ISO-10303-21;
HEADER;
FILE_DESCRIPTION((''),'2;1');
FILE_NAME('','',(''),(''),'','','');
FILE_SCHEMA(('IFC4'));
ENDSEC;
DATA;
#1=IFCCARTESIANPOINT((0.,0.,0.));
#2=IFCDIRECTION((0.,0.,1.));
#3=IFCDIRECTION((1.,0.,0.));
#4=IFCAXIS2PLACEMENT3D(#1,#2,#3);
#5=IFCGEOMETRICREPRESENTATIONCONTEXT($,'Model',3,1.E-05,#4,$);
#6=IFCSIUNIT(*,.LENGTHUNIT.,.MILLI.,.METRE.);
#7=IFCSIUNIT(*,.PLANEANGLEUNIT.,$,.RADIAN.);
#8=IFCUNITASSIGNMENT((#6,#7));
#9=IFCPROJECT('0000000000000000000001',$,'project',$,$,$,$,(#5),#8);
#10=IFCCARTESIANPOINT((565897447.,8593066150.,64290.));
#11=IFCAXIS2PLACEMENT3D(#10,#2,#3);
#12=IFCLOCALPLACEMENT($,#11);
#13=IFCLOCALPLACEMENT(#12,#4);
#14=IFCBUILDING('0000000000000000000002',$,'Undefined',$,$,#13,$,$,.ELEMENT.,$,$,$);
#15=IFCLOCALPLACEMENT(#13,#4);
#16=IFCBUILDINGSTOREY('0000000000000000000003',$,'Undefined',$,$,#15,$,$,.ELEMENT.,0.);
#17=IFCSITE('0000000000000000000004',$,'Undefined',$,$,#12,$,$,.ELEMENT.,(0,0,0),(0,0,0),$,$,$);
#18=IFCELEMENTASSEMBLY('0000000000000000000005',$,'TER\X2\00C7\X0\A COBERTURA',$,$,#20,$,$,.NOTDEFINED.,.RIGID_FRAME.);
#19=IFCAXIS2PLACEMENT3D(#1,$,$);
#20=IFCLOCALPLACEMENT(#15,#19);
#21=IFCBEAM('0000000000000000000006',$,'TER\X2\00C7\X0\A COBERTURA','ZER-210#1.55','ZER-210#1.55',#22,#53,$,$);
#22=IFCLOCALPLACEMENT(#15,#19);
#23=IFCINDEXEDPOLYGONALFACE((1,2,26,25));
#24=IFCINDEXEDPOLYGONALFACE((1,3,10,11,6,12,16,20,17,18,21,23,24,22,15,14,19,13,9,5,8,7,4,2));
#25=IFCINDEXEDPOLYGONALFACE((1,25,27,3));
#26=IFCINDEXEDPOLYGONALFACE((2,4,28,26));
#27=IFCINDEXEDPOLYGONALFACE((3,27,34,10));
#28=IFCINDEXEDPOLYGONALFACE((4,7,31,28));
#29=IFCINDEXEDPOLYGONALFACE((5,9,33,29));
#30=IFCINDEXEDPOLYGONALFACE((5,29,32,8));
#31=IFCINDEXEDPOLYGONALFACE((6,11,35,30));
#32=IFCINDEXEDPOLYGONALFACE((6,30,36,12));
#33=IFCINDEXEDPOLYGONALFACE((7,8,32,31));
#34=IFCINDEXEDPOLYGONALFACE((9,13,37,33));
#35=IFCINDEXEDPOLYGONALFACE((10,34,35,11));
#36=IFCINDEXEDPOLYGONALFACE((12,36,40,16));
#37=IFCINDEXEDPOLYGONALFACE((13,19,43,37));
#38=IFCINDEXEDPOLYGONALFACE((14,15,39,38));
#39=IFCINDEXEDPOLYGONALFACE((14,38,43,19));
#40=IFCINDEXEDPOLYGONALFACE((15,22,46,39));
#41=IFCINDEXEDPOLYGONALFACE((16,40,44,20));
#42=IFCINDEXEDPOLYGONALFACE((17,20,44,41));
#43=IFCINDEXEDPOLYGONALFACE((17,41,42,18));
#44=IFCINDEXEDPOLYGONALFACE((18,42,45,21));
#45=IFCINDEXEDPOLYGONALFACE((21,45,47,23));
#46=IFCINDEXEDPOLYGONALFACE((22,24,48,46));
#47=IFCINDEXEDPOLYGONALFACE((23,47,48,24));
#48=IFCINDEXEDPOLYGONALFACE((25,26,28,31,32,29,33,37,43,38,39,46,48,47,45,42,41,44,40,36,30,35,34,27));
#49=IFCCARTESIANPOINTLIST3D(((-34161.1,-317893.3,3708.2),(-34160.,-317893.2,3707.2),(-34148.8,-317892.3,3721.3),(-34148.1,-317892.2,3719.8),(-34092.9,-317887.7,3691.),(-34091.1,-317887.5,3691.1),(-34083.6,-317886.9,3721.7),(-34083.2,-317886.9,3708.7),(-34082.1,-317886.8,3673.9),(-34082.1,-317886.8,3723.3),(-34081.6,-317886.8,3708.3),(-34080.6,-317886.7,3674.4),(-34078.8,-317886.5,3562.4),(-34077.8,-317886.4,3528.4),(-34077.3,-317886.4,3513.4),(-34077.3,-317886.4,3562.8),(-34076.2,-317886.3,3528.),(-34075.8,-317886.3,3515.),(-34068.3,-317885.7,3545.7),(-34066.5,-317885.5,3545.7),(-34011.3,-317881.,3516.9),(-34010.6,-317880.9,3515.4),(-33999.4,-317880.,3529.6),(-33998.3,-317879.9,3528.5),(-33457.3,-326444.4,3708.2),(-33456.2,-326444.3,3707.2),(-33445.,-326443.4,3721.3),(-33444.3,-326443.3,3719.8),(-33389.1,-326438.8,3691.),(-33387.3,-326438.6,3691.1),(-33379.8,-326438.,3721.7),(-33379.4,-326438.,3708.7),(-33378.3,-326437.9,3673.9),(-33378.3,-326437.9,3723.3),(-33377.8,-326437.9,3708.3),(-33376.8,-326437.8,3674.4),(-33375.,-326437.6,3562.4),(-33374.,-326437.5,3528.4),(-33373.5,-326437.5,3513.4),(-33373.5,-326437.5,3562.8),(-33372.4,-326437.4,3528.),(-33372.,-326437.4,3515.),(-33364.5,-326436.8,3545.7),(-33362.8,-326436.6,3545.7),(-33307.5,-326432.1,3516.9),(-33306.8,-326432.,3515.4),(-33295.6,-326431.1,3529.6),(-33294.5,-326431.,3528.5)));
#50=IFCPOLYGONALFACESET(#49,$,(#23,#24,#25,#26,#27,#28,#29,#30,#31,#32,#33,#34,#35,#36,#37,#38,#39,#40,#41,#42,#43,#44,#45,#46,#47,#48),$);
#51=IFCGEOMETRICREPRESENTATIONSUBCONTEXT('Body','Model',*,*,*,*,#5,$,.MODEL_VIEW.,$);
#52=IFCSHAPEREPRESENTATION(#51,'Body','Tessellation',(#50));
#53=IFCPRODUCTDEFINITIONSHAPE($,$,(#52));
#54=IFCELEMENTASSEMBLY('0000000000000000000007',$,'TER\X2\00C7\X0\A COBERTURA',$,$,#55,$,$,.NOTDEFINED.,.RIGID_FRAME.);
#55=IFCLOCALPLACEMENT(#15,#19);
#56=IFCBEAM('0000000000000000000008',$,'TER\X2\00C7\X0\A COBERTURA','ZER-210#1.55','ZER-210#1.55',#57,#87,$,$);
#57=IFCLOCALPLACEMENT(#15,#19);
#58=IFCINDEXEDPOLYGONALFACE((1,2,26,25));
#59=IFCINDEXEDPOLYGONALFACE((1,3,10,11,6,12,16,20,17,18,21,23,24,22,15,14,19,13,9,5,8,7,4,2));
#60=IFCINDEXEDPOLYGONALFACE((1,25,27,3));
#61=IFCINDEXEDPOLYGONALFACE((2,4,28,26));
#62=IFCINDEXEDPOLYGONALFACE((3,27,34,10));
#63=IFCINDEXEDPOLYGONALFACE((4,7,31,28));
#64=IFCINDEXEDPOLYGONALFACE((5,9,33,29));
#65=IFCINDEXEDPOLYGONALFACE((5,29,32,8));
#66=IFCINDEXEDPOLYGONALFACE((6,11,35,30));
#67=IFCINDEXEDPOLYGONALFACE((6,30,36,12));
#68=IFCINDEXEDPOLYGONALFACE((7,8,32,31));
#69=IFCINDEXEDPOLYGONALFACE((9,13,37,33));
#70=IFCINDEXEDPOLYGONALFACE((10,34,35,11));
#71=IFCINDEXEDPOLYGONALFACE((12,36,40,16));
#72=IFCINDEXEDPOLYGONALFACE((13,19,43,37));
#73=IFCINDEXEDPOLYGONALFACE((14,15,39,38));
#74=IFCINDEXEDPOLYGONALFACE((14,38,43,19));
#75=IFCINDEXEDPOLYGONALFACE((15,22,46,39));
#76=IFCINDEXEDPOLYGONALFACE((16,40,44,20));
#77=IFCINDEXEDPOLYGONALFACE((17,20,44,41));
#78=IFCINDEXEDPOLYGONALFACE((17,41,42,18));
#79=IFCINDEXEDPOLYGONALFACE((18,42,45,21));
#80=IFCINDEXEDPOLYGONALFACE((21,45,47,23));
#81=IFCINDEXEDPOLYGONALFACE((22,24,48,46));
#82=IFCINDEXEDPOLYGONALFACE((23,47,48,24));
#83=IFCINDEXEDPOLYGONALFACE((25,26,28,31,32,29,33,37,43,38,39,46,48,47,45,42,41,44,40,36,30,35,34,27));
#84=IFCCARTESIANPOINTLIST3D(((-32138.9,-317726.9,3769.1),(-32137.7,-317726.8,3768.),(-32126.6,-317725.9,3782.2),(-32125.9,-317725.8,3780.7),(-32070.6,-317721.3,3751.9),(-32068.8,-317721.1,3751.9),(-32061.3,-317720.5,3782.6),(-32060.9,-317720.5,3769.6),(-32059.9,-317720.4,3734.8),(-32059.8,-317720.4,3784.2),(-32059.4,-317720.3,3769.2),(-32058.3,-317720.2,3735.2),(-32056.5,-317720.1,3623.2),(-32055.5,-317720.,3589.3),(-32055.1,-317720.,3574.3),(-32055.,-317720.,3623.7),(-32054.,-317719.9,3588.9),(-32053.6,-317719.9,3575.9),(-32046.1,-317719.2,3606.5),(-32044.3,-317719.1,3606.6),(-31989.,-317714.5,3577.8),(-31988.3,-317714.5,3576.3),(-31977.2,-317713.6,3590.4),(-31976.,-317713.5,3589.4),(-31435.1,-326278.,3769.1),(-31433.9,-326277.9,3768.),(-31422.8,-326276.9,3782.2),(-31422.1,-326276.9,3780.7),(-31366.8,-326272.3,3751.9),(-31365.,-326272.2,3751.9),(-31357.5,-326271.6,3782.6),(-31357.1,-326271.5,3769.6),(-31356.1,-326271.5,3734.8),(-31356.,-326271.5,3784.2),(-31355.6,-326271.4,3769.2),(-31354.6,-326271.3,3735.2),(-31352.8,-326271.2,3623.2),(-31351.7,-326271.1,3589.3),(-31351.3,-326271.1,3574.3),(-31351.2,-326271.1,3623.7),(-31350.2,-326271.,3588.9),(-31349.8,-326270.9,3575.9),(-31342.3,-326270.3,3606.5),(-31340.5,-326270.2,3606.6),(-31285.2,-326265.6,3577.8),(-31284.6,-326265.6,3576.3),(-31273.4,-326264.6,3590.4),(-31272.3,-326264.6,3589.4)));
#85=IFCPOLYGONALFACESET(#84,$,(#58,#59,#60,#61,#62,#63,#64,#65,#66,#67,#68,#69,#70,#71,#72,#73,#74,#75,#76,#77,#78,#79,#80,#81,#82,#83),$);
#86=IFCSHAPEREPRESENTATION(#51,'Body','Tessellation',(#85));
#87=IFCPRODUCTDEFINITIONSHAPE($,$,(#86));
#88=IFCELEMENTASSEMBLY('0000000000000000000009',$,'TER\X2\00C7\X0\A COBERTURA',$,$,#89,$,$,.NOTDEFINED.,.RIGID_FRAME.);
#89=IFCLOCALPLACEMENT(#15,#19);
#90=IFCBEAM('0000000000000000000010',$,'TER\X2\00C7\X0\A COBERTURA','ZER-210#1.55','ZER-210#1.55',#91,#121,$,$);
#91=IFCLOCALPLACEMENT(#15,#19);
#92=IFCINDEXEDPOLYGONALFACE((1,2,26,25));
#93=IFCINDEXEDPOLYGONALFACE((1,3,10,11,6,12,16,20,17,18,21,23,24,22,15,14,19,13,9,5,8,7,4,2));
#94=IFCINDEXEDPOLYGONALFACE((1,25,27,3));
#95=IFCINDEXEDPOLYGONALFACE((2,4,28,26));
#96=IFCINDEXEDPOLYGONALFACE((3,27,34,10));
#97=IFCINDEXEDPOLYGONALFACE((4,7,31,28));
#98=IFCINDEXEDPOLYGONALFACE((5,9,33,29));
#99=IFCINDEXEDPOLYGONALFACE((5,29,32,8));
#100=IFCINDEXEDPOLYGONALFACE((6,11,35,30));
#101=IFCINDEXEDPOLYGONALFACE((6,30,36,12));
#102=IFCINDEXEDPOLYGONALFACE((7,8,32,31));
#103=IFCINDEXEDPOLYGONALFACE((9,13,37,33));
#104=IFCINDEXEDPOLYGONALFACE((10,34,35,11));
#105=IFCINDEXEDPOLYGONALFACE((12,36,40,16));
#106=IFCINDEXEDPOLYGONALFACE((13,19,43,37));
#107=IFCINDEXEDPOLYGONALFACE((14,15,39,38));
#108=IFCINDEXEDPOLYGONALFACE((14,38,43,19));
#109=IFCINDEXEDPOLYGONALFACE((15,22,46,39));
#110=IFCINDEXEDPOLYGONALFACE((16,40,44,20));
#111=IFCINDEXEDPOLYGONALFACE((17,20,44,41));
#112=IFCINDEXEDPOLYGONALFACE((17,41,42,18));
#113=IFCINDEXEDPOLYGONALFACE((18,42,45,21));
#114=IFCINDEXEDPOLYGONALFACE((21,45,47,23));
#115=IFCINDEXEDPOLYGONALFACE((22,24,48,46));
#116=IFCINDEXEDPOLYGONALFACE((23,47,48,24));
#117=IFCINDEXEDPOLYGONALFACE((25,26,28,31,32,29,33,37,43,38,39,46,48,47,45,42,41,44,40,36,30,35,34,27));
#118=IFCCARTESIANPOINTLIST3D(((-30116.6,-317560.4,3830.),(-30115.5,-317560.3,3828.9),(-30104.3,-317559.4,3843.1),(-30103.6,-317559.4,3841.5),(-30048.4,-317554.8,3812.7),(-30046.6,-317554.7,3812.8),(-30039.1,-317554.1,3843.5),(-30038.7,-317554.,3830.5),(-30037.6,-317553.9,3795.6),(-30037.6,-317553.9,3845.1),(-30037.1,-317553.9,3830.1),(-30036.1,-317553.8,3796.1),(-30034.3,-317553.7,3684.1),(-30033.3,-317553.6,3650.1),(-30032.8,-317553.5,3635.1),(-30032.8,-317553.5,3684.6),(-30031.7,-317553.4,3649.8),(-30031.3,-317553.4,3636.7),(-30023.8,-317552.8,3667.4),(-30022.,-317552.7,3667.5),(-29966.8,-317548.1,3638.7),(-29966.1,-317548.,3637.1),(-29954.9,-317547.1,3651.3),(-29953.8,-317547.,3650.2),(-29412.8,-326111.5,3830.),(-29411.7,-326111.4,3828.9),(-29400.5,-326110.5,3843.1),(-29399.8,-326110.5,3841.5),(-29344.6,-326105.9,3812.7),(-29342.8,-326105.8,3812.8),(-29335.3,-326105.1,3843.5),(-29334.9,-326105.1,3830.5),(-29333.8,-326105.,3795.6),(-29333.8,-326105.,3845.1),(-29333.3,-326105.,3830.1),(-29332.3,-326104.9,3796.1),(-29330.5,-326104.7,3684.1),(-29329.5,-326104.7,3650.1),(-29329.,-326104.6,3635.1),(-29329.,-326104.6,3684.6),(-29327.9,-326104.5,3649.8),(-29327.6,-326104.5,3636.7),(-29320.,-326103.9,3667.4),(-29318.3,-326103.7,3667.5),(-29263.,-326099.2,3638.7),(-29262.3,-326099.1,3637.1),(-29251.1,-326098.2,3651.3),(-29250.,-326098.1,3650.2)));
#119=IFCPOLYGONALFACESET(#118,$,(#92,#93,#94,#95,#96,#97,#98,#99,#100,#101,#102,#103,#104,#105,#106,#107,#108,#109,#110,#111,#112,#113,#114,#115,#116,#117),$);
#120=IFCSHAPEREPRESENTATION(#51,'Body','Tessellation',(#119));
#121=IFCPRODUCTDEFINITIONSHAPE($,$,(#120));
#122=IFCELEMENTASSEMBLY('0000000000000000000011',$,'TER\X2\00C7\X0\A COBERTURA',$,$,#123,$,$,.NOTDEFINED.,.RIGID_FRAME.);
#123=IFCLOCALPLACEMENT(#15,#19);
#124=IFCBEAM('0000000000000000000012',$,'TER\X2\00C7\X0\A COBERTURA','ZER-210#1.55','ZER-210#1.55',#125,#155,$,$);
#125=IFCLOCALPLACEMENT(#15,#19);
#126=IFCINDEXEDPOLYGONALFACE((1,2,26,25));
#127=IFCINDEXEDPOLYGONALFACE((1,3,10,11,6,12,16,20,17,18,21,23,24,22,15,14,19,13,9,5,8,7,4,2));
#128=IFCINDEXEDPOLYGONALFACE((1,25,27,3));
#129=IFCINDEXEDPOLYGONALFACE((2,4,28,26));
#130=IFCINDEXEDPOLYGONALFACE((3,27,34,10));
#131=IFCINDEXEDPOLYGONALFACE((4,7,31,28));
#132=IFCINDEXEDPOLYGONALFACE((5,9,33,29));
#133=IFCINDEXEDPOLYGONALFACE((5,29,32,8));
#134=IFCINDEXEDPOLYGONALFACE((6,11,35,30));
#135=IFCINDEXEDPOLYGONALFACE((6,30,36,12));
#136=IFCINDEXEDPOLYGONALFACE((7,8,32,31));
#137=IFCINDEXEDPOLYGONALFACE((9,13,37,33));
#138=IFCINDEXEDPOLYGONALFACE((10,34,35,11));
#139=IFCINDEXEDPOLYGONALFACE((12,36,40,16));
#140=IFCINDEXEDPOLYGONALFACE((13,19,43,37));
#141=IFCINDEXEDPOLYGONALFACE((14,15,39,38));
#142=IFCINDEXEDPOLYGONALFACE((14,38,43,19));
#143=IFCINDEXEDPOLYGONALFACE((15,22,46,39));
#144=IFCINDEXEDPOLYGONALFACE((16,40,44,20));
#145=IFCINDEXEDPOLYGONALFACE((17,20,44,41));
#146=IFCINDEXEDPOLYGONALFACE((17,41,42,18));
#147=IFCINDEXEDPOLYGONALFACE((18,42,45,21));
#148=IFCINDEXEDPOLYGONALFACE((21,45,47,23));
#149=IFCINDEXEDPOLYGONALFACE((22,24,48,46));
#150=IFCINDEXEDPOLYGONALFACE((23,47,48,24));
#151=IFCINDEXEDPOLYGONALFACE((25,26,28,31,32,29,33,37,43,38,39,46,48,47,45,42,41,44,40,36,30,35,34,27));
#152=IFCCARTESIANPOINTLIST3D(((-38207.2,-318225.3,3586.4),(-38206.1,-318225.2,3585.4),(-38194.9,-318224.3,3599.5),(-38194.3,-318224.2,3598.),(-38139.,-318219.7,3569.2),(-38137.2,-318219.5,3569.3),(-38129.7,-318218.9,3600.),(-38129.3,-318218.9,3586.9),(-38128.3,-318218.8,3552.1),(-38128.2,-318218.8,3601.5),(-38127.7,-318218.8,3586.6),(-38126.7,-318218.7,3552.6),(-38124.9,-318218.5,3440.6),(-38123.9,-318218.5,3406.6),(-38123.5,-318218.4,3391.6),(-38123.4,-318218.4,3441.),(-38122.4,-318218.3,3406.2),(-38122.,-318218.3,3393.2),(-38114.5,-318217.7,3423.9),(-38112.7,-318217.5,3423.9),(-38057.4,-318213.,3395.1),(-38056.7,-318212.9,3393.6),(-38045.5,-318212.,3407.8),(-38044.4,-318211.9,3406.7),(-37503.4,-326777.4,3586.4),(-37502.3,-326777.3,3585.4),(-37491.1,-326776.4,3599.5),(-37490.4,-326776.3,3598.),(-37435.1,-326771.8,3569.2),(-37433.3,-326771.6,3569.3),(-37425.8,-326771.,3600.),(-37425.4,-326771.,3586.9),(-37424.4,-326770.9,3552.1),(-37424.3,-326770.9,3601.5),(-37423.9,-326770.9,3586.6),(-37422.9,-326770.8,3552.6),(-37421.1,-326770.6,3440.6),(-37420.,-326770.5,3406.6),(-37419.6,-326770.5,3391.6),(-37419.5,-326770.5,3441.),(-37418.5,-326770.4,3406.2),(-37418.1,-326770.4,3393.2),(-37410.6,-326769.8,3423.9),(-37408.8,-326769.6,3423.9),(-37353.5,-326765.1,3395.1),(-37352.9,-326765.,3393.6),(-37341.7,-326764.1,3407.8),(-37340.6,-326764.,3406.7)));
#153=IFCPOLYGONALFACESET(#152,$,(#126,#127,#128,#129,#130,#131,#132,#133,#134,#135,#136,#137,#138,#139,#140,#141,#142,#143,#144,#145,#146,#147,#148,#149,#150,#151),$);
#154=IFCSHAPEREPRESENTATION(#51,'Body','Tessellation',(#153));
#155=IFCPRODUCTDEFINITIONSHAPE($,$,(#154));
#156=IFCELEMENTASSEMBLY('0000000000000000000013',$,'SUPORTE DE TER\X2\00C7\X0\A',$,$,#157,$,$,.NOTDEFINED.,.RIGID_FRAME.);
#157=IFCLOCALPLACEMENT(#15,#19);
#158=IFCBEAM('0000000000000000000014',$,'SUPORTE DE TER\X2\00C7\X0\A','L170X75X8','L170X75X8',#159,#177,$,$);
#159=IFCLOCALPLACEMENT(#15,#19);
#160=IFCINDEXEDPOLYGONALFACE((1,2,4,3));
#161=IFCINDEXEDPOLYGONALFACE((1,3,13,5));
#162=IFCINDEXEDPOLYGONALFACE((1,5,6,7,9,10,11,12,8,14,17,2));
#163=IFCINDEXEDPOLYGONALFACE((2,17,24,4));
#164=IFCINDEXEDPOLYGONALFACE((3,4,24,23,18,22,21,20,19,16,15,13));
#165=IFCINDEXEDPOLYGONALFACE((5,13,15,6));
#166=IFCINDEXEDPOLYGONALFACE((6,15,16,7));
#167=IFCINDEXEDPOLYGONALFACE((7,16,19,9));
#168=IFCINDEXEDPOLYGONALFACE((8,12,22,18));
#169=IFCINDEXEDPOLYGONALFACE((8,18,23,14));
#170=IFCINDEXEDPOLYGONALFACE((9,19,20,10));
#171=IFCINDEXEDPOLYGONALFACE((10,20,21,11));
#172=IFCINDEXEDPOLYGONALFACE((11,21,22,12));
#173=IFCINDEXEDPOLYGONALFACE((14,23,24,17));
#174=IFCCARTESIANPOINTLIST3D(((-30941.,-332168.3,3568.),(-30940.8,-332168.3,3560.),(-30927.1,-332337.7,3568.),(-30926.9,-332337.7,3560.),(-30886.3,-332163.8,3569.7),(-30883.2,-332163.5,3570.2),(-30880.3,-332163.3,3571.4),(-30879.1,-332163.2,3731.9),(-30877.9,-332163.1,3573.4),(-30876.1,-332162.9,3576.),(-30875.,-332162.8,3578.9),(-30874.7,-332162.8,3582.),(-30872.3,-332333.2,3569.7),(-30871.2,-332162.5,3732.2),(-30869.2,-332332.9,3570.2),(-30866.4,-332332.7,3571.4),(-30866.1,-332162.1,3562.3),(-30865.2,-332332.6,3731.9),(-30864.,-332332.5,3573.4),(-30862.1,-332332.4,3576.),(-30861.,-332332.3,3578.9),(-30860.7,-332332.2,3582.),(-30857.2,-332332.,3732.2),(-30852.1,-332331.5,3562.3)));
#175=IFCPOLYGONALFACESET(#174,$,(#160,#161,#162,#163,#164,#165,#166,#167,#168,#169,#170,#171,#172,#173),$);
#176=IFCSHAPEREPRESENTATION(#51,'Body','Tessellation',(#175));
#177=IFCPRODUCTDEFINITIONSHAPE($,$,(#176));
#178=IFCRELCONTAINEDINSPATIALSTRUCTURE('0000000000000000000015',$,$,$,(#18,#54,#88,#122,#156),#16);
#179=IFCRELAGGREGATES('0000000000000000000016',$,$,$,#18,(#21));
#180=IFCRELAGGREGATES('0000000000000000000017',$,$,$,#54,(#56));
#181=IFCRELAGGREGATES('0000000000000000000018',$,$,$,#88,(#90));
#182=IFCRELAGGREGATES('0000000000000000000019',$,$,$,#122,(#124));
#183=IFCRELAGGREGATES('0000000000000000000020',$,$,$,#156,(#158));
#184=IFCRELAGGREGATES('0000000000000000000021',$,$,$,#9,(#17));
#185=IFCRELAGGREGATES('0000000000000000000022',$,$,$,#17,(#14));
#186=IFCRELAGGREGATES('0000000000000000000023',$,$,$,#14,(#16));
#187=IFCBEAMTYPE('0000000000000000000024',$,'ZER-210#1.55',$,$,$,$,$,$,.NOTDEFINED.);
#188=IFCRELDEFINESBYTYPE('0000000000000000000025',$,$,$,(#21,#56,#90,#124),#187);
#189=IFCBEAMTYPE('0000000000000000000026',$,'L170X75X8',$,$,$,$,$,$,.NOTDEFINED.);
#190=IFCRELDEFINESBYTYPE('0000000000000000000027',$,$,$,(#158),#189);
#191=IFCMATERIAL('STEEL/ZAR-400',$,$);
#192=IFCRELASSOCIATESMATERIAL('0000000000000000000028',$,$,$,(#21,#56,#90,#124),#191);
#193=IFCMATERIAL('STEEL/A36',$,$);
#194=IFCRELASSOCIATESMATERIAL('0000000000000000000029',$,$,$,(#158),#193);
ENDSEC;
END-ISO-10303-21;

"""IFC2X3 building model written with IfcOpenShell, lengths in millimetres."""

from ifc_helpers import new_model, si_unit, frame, origin_with_axes, origin_2d_with_axis, place, context, subcontext, project, spatial, polyline, l_section, outline, extrude, material, type_object, element, aggregate, save


model = new_model("IFC2X3")

# Units and contexts
model_context = context("Model", 3, precision=1e-05, world=origin_with_axes())
body_context = subcontext(model_context, "Body", "Model", "MODEL_VIEW")
ifc_project = project(units=[si_unit("LENGTHUNIT", "METRE", prefix="MILLI"), si_unit("PLANEANGLEUNIT", "RADIAN")], contexts=[model_context])

# Site, building, storey
site_placement = place(None, frame((565897447.0, 8593066150.0, 64290.0), z_axis=(0.0, 0.0, 1.0), x_axis=(1.0, 0.0, 0.0)))
site = spatial("IfcSite", under=ifc_project, at=site_placement, Name="Undefined", CompositionType="ELEMENT", RefLatitude=(0, 0, 0), RefLongitude=(0, 0, 0))
building_placement = place(site_placement, origin_with_axes())
building = spatial("IfcBuilding", under=site, at=building_placement, Name="Undefined", CompositionType="ELEMENT")
storey_placement = place(building_placement, origin_with_axes())
storey = spatial("IfcBuildingStorey", under=building, at=storey_placement, Name="Undefined", CompositionType="ELEMENT", Elevation=0.0)

# Element assemblies, beams
ifc_material_1 = material(Name="STEEL/ZAR-400")
beam_type_1 = type_object("IfcBeamType", Name="ZER-210#1.55", PredefinedType="NOTDEFINED")
assembly_1_placement = place(storey_placement, origin_with_axes())
assembly_1 = element("IfcElementAssembly", 1, at=assembly_1_placement, inside=storey, Name="TERÇA COBERTURA", AssemblyPlace="NOTDEFINED", PredefinedType="RIGID_FRAME")
beam_1_placement = place(assembly_1_placement, frame((-33375.9, -326437.7, 3618.4), z_axis=(-0.029885, -0.00246, 0.99955), x_axis=(-0.082025, 0.99663, 0.0)))
beam_1 = element("IfcBeam", 2, at=beam_1_placement, type_object=beam_type_1, material=ifc_material_1, Name="TERÇA COBERTURA", Description="ZER-210#1.55", ObjectType="ZER-210#1.55", context=body_context, shape_type="SweptSolid", body=[
    extrude(outline(polyline([(65.6, -103.4), (77.9, -91.2), (79.0, -92.3), (66.2, -105.0), (-0.8, -105.0), (-0.8, -90.0), (9.2, -73.0), (-0.8, -56.0), (-0.8, 55.6), (-11.0, 73.0), (-0.8, 90.4), (-0.8, 103.5), (-65.6, 103.4), (-77.9, 91.2), (-79.0, 92.3), (-66.2, 105.0), (0.8, 105.0), (0.8, 90.0), (-9.2, 73.0), (0.8, 56.0), (0.8, -55.6), (11.0, -73.0), (0.8, -90.4), (0.8, -103.5), (65.6, -103.4)])), frame((8580.0, 0.0, 0.0), z_axis=(-1.0, 0.0, 0.0), x_axis=(0.0, -1.0, 0.0)), (0.0, 0.0, 1.0), 8580.0),
])
aggregate(assembly_1, [beam_1])
assembly_2_placement = place(storey_placement, origin_with_axes())
assembly_2 = element("IfcElementAssembly", 3, at=assembly_2_placement, inside=storey, Name="TERÇA COBERTURA", AssemblyPlace="NOTDEFINED", PredefinedType="RIGID_FRAME")
beam_2_placement = place(assembly_2_placement, frame((-31353.7, -326271.3, 3679.2), z_axis=(-0.029885, -0.00246, 0.99955), x_axis=(-0.082025, 0.99663, 0.0)))
beam_2 = element("IfcBeam", 4, at=beam_2_placement, type_object=beam_type_1, material=ifc_material_1, Name="TERÇA COBERTURA", Description="ZER-210#1.55", ObjectType="ZER-210#1.55", context=body_context, shape_type="SweptSolid", body=[
    extrude(outline(polyline([(65.6, -103.4), (77.9, -91.2), (79.0, -92.3), (66.2, -105.0), (-0.8, -105.0), (-0.8, -90.0), (9.2, -73.0), (-0.8, -56.0), (-0.8, 55.6), (-11.0, 73.0), (-0.8, 90.4), (-0.8, 103.5), (-65.6, 103.4), (-77.9, 91.2), (-79.0, 92.3), (-66.2, 105.0), (0.8, 105.0), (0.8, 90.0), (-9.2, 73.0), (0.8, 56.0), (0.8, -55.6), (11.0, -73.0), (0.8, -90.4), (0.8, -103.5), (65.6, -103.4)])), frame((8580.0, 0.0, 0.0), z_axis=(-1.0, 0.0, 0.0), x_axis=(0.0, -1.0, 0.0)), (0.0, 0.0, 1.0), 8580.0),
])
aggregate(assembly_2, [beam_2])
assembly_3_placement = place(storey_placement, origin_with_axes())
assembly_3 = element("IfcElementAssembly", 5, at=assembly_3_placement, inside=storey, Name="TERÇA COBERTURA", AssemblyPlace="NOTDEFINED", PredefinedType="RIGID_FRAME")
beam_3_placement = place(assembly_3_placement, frame((-29331.4, -326104.8, 3740.1), z_axis=(-0.029885, -0.00246, 0.99955), x_axis=(-0.082025, 0.99663, 0.0)))
beam_3 = element("IfcBeam", 6, at=beam_3_placement, type_object=beam_type_1, material=ifc_material_1, Name="TERÇA COBERTURA", Description="ZER-210#1.55", ObjectType="ZER-210#1.55", context=body_context, shape_type="SweptSolid", body=[
    extrude(outline(polyline([(65.6, -103.4), (77.9, -91.2), (79.0, -92.3), (66.2, -105.0), (-0.8, -105.0), (-0.8, -90.0), (9.2, -73.0), (-0.8, -56.0), (-0.8, 55.6), (-11.0, 73.0), (-0.8, 90.4), (-0.8, 103.5), (-65.6, 103.4), (-77.9, 91.2), (-79.0, 92.3), (-66.2, 105.0), (0.8, 105.0), (0.8, 90.0), (-9.2, 73.0), (0.8, 56.0), (0.8, -55.6), (11.0, -73.0), (0.8, -90.4), (0.8, -103.5), (65.6, -103.4)])), frame((8580.0, 0.0, 0.0), z_axis=(-1.0, 0.0, 0.0), x_axis=(0.0, -1.0, 0.0)), (0.0, 0.0, 1.0), 8580.0),
])
aggregate(assembly_3, [beam_3])
assembly_4_placement = place(storey_placement, origin_with_axes())
assembly_4 = element("IfcElementAssembly", 7, at=assembly_4_placement, inside=storey, Name="TERÇA COBERTURA", AssemblyPlace="NOTDEFINED", PredefinedType="RIGID_FRAME")
beam_4_placement = place(assembly_4_placement, frame((-37422.0, -326770.7, 3496.6), z_axis=(-0.029885, -0.00246, 0.99955), x_axis=(-0.082025, 0.99663, 0.0)))
beam_4 = element("IfcBeam", 8, at=beam_4_placement, type_object=beam_type_1, material=ifc_material_1, Name="TERÇA COBERTURA", Description="ZER-210#1.55", ObjectType="ZER-210#1.55", context=body_context, shape_type="SweptSolid", body=[
    extrude(outline(polyline([(65.6, -103.4), (77.9, -91.2), (79.0, -92.3), (66.2, -105.0), (-0.8, -105.0), (-0.8, -90.0), (9.2, -73.0), (-0.8, -56.0), (-0.8, 55.6), (-11.0, 73.0), (-0.8, 90.4), (-0.8, 103.5), (-65.6, 103.4), (-77.9, 91.2), (-79.0, 92.3), (-66.2, 105.0), (0.8, 105.0), (0.8, 90.0), (-9.2, 73.0), (0.8, 56.0), (0.8, -55.6), (11.0, -73.0), (0.8, -90.4), (0.8, -103.5), (65.6, -103.4)])), frame((8581.0, 0.0, 0.0), z_axis=(-1.0, 0.0, 0.0), x_axis=(0.0, -1.0, 0.0)), (0.0, 0.0, 1.0), 8581.0),
])
aggregate(assembly_4, [beam_4])
assembly_5_placement = place(storey_placement, origin_with_axes())
assembly_5 = element("IfcElementAssembly", 9, at=assembly_5_placement, inside=storey, Name="SUPORTE DE TERÇA", AssemblyPlace="NOTDEFINED", PredefinedType="RIGID_FRAME")
ifc_material_2 = material(Name="STEEL/A36")
beam_type_2 = type_object("IfcBeamType", Name="L170X75X8", PredefinedType="NOTDEFINED")
beam_5_placement = place(assembly_5_placement, frame((-30906.0, -332165.4, 3646.1), z_axis=(-0.029885, -0.00246, 0.99955), x_axis=(0.082025, -0.99663, 0.0)))
beam_5 = element("IfcBeam", 10, at=beam_5_placement, type_object=beam_type_2, material=ifc_material_2, Name="SUPORTE DE TERÇA", Description="L170X75X8", ObjectType="L170X75X8", context=body_context, shape_type="SweptSolid", body=[
    extrude(l_section(Depth=170.0, Width=75.0, Thickness=8.0, FilletRadius=12.0, at=origin_2d_with_axis()), frame((170.0, 0.0, 0.0), z_axis=(-1.0, 0.0, 0.0), x_axis=(0.0, -1.0, 0.0)), (0.0, 0.0, 1.0), 170.0),
])
aggregate(assembly_5, [beam_5])

save(model, "model.ifc")
